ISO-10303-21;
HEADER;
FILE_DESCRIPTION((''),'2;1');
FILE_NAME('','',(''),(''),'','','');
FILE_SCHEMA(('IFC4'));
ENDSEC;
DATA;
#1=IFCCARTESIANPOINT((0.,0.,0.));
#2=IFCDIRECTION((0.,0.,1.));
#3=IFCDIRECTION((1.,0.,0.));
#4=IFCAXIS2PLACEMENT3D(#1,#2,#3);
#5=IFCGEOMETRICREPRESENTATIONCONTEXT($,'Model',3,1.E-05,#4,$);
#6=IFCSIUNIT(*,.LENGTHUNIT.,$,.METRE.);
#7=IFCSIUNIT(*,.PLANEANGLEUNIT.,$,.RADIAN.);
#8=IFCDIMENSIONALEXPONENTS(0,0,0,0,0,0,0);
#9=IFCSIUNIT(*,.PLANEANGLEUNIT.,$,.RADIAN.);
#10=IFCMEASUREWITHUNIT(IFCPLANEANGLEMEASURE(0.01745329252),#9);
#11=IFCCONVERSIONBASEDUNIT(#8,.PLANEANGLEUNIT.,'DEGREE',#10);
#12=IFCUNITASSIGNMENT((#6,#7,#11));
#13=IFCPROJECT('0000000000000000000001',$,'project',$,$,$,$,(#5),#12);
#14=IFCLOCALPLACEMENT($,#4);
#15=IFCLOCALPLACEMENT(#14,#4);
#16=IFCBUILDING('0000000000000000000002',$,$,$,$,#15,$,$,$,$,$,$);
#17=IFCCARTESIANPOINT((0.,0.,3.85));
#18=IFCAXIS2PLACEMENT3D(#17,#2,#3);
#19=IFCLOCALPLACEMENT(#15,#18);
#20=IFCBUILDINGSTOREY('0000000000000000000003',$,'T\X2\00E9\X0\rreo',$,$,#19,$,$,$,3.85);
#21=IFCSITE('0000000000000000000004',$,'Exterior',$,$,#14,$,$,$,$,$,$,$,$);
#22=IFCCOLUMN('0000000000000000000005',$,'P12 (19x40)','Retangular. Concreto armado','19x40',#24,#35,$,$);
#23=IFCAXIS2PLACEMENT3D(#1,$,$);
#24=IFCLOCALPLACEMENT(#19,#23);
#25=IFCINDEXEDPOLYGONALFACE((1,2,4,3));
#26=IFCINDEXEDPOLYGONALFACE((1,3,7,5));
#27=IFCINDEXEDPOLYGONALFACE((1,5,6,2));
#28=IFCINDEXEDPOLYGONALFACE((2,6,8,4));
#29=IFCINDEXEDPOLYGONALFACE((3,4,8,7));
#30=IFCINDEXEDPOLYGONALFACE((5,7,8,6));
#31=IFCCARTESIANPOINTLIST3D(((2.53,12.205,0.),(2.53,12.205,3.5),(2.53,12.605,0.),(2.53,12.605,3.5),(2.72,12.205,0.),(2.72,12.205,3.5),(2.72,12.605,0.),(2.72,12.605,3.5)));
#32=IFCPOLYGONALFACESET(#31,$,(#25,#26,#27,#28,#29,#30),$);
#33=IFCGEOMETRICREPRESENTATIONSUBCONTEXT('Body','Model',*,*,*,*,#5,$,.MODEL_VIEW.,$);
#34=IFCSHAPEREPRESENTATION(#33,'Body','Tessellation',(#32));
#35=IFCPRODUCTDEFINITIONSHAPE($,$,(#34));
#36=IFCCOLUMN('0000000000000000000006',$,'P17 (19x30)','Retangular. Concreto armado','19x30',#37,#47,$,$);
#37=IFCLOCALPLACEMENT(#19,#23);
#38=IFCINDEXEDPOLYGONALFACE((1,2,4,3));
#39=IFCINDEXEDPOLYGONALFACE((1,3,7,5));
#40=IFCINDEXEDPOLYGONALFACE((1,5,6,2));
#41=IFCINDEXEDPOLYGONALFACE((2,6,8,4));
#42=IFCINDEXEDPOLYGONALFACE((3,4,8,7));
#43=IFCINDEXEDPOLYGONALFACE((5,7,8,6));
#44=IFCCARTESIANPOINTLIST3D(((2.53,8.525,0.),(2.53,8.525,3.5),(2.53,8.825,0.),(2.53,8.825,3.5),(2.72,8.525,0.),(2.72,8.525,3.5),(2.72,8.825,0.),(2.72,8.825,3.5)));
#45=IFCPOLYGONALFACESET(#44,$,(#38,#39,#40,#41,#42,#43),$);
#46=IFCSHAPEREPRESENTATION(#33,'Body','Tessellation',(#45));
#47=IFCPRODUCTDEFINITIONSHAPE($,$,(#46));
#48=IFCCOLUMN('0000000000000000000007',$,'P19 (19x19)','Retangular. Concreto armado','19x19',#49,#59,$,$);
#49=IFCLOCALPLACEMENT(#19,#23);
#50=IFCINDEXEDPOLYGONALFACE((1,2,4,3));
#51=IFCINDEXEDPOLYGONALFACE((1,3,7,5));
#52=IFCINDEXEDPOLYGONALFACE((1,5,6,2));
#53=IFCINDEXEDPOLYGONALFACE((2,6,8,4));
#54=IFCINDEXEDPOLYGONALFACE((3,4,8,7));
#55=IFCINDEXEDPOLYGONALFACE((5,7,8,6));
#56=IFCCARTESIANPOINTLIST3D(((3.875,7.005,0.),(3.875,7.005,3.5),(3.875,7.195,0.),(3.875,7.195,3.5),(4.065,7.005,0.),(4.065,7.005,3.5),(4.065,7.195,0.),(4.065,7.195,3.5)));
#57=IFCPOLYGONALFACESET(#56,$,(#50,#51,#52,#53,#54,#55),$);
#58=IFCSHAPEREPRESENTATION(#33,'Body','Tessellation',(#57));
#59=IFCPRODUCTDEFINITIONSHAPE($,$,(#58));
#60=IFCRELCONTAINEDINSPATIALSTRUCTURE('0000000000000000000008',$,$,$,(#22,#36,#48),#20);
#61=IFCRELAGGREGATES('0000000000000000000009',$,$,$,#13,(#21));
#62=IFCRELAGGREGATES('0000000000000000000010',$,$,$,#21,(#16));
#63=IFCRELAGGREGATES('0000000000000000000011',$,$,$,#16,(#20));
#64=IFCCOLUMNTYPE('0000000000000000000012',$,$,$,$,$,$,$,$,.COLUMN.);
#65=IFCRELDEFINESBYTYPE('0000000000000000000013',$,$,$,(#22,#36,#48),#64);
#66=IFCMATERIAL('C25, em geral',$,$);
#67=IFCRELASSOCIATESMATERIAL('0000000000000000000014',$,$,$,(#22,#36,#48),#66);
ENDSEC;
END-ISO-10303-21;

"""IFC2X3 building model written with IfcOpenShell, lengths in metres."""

from ifc_helpers import new_model, entity, si_unit, converted_unit, frame, frame_2d, origin_with_axes, place, context, subcontext, project, spatial, rectangle, extrude, material, type_object, element, save


model = new_model("IFC2X3")

# Units and contexts
model_context = context("Model", 3, precision=1e-05, world=origin_with_axes())
body_context = subcontext(model_context, "Body", "Model", "MODEL_VIEW")
ifc_project = project(units=[si_unit("LENGTHUNIT", "METRE"), si_unit("PLANEANGLEUNIT", "RADIAN"), converted_unit("PLANEANGLEUNIT", "DEGREE", entity("IfcPlaneAngleMeasure", 0.01745329252), si_unit("PLANEANGLEUNIT", "RADIAN"), dimensions=[0, 0, 0, 0, 0, 0, 0])], contexts=[model_context])

# Site, building, storey
site_placement = place(None, origin_with_axes())
site = spatial("IfcSite", under=ifc_project, at=site_placement, Name="Exterior")
building_placement = place(site_placement, origin_with_axes())
building = spatial("IfcBuilding", under=site, at=building_placement)
storey_placement = place(building_placement, frame((0.0, 0.0, 3.85), z_axis=(0.0, 0.0, 1.0), x_axis=(1.0, 0.0, 0.0)))
storey = spatial("IfcBuildingStorey", under=building, at=storey_placement, Name="Térreo", Elevation=3.85)

# Columns
ifc_material_1 = material(Name="C25, em geral")
column_type = type_object("IfcColumnType", PredefinedType="COLUMN")
column_1_placement = place(storey_placement, frame((2.53, 12.205, 0.0), z_axis=(0.0, 0.0, 1.0), x_axis=(1.0, 0.0, 0.0)))
element("IfcColumn", 1, at=column_1_placement, inside=storey, type_object=column_type, material=ifc_material_1, Name="P12 (19x40)", Description="Retangular. Concreto armado", ObjectType="19x40", context=body_context, shape_type="SweptSolid", body=[
    extrude(rectangle(XDim=0.19, YDim=0.4, at=frame_2d((0.095, 0.2), x_axis=(1.0, 0.0))), origin_with_axes(), (0.0, 0.0, 1.0), 3.5),
])
column_2_placement = place(storey_placement, frame((2.53, 8.525, 0.0), z_axis=(0.0, 0.0, 1.0), x_axis=(1.0, 0.0, 0.0)))
element("IfcColumn", 2, at=column_2_placement, inside=storey, type_object=column_type, material=ifc_material_1, Name="P17 (19x30)", Description="Retangular. Concreto armado", ObjectType="19x30", context=body_context, shape_type="SweptSolid", body=[
    extrude(rectangle(XDim=0.19, YDim=0.3, at=frame_2d((0.095, 0.15), x_axis=(1.0, 0.0))), origin_with_axes(), (0.0, 0.0, 1.0), 3.5),
])
column_3_placement = place(storey_placement, frame((3.875, 7.005, 0.0), z_axis=(0.0, 0.0, 1.0), x_axis=(1.0, 0.0, 0.0)))
element("IfcColumn", 3, at=column_3_placement, inside=storey, type_object=column_type, material=ifc_material_1, Name="P19 (19x19)", Description="Retangular. Concreto armado", ObjectType="19x19", context=body_context, shape_type="SweptSolid", body=[
    extrude(rectangle(XDim=0.19, YDim=0.19, at=frame_2d((0.095, 0.095), x_axis=(1.0, 0.0))), origin_with_axes(), (0.0, 0.0, 1.0), 3.5),
])

save(model, "model.ifc")
